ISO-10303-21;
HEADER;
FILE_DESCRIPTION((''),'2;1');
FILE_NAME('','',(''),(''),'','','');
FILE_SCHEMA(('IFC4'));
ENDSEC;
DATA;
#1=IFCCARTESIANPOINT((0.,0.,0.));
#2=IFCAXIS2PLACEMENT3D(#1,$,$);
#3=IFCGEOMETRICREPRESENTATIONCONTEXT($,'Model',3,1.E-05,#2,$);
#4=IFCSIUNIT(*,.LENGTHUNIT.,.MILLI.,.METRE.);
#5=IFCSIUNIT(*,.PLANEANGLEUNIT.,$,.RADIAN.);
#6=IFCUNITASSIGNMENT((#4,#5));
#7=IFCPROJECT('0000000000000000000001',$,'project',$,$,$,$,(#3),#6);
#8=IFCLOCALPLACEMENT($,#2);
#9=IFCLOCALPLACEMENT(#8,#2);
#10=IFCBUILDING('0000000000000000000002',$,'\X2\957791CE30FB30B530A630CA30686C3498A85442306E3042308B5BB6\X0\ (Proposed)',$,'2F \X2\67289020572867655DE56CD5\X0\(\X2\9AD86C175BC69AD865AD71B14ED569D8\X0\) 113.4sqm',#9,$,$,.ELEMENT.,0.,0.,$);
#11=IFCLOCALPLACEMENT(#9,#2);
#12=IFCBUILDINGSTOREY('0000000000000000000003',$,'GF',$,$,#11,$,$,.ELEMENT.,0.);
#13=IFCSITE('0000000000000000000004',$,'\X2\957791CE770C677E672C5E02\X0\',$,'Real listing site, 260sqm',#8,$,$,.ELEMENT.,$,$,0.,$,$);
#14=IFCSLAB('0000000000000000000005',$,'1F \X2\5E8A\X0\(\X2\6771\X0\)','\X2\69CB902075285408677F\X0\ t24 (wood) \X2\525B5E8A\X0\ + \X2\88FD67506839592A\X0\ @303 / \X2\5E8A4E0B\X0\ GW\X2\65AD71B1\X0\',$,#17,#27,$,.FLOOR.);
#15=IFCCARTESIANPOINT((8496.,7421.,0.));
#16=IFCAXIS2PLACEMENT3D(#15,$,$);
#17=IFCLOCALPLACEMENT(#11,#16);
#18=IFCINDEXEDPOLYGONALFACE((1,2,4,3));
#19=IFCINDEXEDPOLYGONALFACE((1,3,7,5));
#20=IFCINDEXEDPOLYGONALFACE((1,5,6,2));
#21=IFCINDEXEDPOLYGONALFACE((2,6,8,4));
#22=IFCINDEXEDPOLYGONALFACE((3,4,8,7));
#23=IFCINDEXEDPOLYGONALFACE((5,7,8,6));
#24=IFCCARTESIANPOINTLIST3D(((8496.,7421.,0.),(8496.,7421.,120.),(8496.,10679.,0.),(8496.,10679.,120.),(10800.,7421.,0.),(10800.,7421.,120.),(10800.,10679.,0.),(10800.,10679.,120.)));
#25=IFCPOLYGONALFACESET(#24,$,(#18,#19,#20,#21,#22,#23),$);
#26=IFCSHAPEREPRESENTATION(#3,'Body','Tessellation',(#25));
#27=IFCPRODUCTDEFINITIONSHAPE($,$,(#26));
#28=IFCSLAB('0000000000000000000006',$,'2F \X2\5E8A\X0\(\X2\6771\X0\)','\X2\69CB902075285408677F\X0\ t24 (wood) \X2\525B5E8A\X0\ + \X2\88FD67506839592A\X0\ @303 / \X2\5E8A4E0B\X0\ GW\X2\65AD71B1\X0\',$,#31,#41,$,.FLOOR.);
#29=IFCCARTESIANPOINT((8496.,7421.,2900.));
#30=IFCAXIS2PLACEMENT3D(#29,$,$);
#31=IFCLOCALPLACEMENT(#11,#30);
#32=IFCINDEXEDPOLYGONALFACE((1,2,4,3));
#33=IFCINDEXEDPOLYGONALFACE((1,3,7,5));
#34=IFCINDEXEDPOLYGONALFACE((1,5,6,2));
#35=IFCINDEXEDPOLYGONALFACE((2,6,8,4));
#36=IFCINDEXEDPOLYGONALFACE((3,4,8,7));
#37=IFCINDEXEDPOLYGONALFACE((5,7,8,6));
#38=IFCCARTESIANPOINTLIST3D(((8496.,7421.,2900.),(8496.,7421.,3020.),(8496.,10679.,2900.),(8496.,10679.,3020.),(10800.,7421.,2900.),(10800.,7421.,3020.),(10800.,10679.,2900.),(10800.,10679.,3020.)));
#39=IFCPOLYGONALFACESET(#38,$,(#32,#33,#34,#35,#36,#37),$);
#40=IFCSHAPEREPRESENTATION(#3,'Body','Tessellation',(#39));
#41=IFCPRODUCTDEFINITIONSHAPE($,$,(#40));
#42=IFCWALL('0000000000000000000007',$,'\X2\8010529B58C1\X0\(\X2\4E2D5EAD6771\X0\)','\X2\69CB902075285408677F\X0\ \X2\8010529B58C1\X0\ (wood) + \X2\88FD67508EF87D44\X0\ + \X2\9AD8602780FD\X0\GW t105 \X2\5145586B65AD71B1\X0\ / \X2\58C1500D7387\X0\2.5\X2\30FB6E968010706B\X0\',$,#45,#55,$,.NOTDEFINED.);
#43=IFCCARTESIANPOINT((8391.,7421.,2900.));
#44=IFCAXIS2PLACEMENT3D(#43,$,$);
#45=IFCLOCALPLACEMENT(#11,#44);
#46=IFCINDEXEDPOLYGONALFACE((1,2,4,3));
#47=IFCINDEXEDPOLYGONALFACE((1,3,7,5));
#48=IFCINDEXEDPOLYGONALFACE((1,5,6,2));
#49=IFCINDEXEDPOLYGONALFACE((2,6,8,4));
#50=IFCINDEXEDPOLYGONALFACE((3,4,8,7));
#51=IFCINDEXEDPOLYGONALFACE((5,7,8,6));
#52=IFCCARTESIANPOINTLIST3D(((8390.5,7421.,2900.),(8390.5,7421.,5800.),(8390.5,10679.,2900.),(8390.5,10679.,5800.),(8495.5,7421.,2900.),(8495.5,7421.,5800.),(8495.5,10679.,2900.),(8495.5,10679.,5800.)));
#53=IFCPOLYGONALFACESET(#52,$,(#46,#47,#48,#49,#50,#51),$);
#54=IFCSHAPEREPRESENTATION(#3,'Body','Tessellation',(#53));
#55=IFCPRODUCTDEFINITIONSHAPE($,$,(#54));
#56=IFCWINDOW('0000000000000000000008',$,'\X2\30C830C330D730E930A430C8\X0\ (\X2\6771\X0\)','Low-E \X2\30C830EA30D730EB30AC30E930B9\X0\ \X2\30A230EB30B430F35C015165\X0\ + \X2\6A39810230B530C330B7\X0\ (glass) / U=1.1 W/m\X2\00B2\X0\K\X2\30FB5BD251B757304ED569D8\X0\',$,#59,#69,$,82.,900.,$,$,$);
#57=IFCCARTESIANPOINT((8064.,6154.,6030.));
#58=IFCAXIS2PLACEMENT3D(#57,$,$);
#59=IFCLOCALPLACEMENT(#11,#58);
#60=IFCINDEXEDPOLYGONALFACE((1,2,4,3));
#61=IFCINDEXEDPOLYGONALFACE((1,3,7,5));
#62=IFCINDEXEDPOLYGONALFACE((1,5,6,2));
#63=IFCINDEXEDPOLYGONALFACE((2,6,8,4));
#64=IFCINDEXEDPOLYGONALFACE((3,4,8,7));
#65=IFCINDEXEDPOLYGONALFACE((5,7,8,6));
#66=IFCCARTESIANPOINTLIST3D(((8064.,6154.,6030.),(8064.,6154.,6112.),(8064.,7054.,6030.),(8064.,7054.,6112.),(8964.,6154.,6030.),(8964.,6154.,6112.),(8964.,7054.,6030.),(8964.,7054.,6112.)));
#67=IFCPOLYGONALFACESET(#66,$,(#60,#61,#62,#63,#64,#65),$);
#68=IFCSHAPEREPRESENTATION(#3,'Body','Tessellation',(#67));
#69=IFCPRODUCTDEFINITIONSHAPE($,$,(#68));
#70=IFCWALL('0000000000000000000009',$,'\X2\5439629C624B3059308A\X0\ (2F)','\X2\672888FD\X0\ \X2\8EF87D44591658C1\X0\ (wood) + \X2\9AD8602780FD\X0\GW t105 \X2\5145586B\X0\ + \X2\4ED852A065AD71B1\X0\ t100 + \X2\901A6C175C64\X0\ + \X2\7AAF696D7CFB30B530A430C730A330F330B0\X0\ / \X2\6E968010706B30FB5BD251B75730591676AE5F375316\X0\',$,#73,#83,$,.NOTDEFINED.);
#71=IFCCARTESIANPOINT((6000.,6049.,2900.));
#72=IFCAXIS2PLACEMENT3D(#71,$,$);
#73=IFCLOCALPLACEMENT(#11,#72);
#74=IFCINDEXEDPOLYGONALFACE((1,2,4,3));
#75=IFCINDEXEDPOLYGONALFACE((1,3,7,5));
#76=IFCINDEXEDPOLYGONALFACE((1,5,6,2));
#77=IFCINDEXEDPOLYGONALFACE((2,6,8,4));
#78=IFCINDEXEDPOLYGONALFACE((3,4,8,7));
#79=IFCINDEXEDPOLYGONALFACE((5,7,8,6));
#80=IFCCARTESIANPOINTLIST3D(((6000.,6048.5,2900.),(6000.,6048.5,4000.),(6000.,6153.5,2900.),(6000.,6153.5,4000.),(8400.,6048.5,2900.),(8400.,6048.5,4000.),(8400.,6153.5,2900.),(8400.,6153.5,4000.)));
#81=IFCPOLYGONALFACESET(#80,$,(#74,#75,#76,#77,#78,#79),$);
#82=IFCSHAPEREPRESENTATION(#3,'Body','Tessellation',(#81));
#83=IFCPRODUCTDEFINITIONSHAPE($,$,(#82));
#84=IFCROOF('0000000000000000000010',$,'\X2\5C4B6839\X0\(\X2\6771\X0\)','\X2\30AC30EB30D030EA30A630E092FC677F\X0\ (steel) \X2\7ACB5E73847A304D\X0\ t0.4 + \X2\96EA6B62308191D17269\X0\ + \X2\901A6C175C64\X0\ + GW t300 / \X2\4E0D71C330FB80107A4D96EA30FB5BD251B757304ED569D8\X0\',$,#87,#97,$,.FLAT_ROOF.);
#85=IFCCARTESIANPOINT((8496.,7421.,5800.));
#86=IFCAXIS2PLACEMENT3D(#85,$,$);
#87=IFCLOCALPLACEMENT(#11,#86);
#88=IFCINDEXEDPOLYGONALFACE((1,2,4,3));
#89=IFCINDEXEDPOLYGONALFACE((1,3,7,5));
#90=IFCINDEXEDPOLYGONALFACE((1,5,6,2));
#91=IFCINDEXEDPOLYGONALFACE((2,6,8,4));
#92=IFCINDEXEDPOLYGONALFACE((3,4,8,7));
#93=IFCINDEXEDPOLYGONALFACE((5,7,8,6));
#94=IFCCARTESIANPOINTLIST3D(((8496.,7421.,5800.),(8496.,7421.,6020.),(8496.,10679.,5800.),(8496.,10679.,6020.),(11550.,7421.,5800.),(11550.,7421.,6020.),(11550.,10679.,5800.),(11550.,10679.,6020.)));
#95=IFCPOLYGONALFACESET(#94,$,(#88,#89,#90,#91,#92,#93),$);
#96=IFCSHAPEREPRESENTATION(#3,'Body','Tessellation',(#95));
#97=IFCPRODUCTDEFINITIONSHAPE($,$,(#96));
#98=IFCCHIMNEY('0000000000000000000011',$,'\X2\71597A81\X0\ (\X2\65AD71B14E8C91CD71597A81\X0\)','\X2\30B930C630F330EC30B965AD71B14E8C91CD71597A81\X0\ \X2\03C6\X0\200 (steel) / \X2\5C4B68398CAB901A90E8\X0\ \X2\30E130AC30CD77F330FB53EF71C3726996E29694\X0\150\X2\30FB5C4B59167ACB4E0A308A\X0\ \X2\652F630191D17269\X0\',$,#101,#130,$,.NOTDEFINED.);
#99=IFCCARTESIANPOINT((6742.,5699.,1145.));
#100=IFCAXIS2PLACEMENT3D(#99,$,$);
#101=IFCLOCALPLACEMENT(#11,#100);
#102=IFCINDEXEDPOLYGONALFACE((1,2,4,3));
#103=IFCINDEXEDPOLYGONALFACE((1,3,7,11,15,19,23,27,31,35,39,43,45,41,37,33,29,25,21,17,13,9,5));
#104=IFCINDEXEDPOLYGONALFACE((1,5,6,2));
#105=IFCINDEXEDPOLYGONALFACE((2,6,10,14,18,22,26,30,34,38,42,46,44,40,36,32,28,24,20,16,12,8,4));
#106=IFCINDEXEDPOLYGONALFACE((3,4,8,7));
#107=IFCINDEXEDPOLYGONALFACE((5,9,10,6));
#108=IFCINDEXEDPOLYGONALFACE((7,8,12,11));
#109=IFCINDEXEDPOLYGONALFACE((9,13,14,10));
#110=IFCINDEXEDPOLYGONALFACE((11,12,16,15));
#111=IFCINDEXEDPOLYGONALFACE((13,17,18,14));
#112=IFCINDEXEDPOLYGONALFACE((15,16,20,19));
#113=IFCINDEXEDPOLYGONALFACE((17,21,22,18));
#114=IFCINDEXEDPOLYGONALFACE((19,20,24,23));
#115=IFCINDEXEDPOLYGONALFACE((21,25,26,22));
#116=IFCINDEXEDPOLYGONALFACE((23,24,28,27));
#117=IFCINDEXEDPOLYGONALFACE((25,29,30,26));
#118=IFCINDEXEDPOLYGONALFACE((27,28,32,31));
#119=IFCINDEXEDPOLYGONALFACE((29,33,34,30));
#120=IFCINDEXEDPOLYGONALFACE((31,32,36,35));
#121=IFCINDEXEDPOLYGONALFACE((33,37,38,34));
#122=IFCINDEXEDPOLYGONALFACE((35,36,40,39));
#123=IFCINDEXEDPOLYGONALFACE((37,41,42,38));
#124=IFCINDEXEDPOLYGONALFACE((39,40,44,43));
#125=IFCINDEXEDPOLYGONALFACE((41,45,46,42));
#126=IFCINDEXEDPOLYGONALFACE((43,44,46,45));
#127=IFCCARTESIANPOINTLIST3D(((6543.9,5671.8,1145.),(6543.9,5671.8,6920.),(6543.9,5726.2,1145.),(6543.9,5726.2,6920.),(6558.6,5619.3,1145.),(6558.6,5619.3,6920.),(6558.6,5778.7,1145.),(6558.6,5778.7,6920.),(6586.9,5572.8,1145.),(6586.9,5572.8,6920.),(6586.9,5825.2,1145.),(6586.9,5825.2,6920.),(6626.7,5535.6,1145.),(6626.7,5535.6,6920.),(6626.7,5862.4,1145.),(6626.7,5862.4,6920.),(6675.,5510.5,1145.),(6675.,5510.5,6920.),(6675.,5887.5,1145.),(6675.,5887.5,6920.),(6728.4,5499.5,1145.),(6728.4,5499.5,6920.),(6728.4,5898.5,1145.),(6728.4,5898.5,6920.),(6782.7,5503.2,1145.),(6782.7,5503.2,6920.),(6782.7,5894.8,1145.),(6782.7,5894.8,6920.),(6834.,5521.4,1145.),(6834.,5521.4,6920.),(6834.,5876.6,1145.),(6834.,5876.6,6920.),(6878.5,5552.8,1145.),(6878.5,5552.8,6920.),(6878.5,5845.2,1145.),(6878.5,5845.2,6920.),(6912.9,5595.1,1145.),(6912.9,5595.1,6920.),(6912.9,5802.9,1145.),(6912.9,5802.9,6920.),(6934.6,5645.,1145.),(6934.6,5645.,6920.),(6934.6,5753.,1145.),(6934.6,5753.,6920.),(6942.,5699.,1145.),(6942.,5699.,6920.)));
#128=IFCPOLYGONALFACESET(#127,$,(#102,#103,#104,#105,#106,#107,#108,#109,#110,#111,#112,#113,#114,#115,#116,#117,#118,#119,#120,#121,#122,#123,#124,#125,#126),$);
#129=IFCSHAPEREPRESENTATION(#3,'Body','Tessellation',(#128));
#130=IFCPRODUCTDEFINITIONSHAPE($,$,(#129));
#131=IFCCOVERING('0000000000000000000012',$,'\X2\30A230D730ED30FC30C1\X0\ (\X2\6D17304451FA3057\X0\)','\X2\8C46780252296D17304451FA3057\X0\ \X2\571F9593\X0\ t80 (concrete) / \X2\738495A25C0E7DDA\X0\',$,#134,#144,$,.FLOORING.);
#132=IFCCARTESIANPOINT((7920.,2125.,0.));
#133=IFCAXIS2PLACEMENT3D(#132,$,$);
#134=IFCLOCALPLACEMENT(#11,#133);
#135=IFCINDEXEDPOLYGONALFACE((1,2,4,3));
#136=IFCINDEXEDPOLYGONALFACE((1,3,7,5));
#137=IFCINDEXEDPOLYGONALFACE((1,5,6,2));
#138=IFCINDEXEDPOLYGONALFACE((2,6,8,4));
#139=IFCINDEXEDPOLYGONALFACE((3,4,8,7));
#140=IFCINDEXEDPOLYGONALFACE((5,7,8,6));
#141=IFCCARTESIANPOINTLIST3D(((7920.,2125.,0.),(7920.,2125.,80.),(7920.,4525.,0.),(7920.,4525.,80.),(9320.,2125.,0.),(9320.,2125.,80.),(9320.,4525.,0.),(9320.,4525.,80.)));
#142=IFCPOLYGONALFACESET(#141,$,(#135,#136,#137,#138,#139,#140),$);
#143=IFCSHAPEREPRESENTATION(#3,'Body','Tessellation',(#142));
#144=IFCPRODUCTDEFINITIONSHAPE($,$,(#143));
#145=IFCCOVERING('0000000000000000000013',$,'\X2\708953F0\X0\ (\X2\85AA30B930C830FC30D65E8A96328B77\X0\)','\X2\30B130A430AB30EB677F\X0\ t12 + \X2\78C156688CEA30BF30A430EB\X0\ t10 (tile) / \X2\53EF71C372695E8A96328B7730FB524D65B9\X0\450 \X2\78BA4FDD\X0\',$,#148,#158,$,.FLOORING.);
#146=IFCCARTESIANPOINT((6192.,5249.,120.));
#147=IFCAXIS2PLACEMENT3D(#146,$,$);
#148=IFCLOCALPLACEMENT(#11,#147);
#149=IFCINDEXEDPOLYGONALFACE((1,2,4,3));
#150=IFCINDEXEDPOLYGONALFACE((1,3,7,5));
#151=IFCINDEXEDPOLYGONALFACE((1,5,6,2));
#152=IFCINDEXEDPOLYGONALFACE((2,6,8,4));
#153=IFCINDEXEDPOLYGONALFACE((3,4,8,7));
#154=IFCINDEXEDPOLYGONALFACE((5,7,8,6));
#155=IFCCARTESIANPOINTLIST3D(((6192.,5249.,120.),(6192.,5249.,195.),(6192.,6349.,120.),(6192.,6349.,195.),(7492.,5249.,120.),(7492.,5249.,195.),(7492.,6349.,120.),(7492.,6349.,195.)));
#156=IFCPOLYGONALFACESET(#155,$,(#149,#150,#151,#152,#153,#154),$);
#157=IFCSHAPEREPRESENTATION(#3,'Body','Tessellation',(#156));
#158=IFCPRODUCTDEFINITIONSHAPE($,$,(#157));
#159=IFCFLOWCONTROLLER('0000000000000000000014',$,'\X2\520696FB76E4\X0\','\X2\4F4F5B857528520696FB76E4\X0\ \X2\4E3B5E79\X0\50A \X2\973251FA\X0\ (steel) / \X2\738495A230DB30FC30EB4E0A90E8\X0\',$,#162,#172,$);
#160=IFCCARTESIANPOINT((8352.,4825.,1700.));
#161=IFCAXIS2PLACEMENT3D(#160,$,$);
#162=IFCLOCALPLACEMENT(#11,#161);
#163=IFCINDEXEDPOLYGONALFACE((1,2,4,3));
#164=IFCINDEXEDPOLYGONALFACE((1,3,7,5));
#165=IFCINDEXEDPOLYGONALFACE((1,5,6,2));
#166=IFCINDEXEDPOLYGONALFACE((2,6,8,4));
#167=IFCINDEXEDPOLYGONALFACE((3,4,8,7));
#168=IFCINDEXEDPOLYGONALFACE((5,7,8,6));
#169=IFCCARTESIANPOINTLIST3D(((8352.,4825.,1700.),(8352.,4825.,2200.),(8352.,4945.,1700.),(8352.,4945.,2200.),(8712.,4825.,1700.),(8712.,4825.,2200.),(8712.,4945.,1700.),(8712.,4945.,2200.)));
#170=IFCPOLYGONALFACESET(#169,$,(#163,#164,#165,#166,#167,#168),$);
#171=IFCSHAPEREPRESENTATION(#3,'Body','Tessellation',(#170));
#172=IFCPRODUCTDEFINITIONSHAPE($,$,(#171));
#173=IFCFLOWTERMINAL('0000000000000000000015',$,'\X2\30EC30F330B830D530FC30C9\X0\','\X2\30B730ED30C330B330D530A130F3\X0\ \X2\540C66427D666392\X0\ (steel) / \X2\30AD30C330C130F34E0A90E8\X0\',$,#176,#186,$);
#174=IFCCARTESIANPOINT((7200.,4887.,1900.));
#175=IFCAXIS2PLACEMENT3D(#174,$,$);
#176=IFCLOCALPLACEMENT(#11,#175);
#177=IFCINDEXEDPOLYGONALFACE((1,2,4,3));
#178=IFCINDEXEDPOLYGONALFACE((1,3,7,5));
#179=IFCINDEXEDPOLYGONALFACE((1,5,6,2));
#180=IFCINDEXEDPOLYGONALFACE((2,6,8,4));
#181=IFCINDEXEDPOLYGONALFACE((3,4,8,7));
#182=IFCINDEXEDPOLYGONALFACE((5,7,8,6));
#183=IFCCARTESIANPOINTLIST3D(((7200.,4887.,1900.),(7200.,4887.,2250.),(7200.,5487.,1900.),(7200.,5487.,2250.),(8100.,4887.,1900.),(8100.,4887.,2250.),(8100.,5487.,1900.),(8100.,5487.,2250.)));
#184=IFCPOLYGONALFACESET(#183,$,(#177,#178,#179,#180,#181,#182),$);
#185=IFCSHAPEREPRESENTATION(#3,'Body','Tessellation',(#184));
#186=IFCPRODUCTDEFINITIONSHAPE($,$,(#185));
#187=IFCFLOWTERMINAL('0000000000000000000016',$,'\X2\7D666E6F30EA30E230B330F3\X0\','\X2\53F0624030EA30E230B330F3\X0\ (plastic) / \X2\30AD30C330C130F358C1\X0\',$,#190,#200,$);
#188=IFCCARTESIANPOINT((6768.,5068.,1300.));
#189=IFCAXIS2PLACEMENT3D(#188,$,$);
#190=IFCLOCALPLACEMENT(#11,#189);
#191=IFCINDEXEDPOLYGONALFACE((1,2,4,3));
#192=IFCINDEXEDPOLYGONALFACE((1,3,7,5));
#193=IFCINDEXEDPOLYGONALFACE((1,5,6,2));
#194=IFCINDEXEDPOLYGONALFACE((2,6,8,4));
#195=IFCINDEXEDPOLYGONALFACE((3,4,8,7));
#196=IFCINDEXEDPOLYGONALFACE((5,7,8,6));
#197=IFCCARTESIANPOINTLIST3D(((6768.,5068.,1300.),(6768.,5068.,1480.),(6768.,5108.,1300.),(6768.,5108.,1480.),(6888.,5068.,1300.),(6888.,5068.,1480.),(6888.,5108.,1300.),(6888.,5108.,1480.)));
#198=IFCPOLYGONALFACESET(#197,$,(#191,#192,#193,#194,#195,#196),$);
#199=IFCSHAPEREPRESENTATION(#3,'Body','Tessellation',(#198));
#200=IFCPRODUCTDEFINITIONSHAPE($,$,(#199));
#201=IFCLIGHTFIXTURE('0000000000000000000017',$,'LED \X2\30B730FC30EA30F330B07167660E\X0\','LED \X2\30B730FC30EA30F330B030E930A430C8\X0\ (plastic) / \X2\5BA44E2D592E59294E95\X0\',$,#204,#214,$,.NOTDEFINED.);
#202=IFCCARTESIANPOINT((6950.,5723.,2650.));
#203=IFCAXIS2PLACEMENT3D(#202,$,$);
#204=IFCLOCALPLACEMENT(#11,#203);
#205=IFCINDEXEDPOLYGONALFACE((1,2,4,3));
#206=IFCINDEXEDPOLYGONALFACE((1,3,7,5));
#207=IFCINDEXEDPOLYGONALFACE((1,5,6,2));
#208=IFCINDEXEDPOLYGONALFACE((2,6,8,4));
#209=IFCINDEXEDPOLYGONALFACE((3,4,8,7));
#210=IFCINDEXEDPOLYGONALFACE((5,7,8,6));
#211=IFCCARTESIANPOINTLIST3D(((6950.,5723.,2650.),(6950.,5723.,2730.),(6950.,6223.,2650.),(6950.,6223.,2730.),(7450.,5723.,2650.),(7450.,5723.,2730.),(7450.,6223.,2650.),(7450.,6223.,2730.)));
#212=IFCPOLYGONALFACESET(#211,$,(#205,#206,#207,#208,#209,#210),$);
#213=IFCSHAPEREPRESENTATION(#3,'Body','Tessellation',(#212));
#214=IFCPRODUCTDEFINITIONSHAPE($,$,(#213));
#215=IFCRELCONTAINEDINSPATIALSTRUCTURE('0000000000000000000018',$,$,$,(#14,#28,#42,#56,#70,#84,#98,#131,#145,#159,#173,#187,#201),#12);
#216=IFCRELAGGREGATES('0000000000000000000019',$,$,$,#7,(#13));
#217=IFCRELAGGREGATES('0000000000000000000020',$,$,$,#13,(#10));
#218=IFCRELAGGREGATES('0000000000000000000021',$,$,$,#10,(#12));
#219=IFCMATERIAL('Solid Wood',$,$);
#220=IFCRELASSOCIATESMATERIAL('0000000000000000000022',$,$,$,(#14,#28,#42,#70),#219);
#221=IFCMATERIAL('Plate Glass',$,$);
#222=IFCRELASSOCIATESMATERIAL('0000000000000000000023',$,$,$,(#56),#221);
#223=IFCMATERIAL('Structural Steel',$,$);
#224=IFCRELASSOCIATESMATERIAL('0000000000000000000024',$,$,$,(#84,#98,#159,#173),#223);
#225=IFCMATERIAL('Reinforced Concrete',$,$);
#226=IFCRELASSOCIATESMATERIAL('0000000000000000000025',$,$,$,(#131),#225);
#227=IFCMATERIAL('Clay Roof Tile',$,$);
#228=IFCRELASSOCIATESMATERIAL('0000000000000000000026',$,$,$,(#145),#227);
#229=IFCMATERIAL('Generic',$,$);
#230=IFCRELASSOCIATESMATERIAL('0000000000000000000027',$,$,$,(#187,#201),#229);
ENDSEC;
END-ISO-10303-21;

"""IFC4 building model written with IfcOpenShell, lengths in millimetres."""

from ifc_helpers import new_model, si_unit, frame, frame_2d, origin, origin_2d, place, context, project, spatial, rectangle, circle, extrude, material, element, save


model = new_model("IFC4")

# Units and contexts
model_context = context("Model", 3, precision=1e-05, world=origin())
ifc_project = project(units=[si_unit("LENGTHUNIT", "METRE", prefix="MILLI"), si_unit("PLANEANGLEUNIT", "RADIAN")], contexts=[model_context])

# Site, building, storey
site_placement = place(None, origin())
site = spatial("IfcSite", under=ifc_project, at=site_placement, Name="長野県松本市", ObjectType="Real listing site, 260sqm", CompositionType="ELEMENT", RefElevation=0.0)
building_placement = place(site_placement, origin())
building = spatial("IfcBuilding", under=site, at=building_placement, Name="長野・サウナと水風呂のある家 (Proposed)", ObjectType="2F 木造在来工法(高気密高断熱仕様) 113.4sqm", CompositionType="ELEMENT", ElevationOfRefHeight=0.0, ElevationOfTerrain=0.0)
storey_placement = place(building_placement, origin())
storey = spatial("IfcBuildingStorey", under=building, at=storey_placement, Name="GF", CompositionType="ELEMENT", Elevation=0.0)

# Shared definitions
ifc_material_1 = material(Name="Solid Wood")

# Slabs
slab_1_placement = place(storey_placement, frame((8496.0, 7421.0, 0.0)))
element("IfcSlab", 1, at=slab_1_placement, inside=storey, material=ifc_material_1, Name="1F 床(東)", Description="構造用合板 t24 (wood) 剛床 + 製材根太 @303 / 床下 GW断熱", PredefinedType="FLOOR", context=model_context, shape_type="SweptSolid", body=[
    extrude(rectangle(XDim=2304.0, YDim=3258.0, at=frame_2d((1152.0, 1629.0))), frame((8496.0, 7421.0, 0.0)), (0.0, 0.0, 1.0), 120.0),
])
slab_2_placement = place(storey_placement, frame((8496.0, 7421.0, 2900.0)))
element("IfcSlab", 2, at=slab_2_placement, inside=storey, material=ifc_material_1, Name="2F 床(東)", Description="構造用合板 t24 (wood) 剛床 + 製材根太 @303 / 床下 GW断熱", PredefinedType="FLOOR", context=model_context, shape_type="SweptSolid", body=[
    extrude(rectangle(XDim=2304.0, YDim=3258.0, at=frame_2d((1152.0, 1629.0))), frame((8496.0, 7421.0, 2900.0)), (0.0, 0.0, 1.0), 120.0),
])

# Wall
wall_1_placement = place(storey_placement, frame((8391.0, 7421.0, 2900.0)))
element("IfcWall", 3, at=wall_1_placement, inside=storey, material=ifc_material_1, Name="耐力壁(中庭東)", Description="構造用合板 耐力壁 (wood) + 製材軸組 + 高性能GW t105 充填断熱 / 壁倍率2.5・準耐火", PredefinedType="NOTDEFINED", context=model_context, shape_type="SweptSolid", body=[
    extrude(rectangle(XDim=105.0, YDim=3258.0, at=frame_2d((52.0, 1629.0))), frame((8391.0, 7421.0, 2900.0)), (0.0, 0.0, 1.0), 2900.0),
])

# Window
ifc_material_2 = material(Name="Plate Glass")
window_placement = place(storey_placement, frame((8064.0, 6154.0, 6030.0)))
element("IfcWindow", 4, at=window_placement, inside=storey, material=ifc_material_2, Name="トップライト (東)", Description="Low-E トリプルガラス アルゴン封入 + 樹脂サッシ (glass) / U=1.1 W/m²K・寒冷地仕様", OverallHeight=82.0, OverallWidth=900.0, context=model_context, shape_type="SweptSolid", body=[
    extrude(rectangle(XDim=900.0, YDim=900.0, at=frame_2d((450.0, 450.0))), frame((8064.0, 6154.0, 6030.0)), (0.0, 0.0, 1.0), 82.0),
])

# Wall
wall_2_placement = place(storey_placement, frame((6000.0, 6049.0, 2900.0)))
element("IfcWall", 5, at=wall_2_placement, inside=storey, material=ifc_material_1, Name="吹抜手すり (2F)", Description="木製 軸組外壁 (wood) + 高性能GW t105 充填 + 付加断熱 t100 + 通気層 + 窯業系サイディング / 準耐火・寒冷地外皮強化", PredefinedType="NOTDEFINED", context=model_context, shape_type="SweptSolid", body=[
    extrude(rectangle(XDim=2400.0, YDim=105.0, at=frame_2d((1200.0, 52.0))), frame((6000.0, 6049.0, 2900.0)), (0.0, 0.0, 1.0), 1100.0),
])

# Roof
ifc_material_3 = material(Name="Structural Steel")
roof_placement = place(storey_placement, frame((8496.0, 7421.0, 5800.0)))
element("IfcRoof", 6, at=roof_placement, inside=storey, material=ifc_material_3, Name="屋根(東)", Description="ガルバリウム鋼板 (steel) 立平葺き t0.4 + 雪止め金物 + 通気層 + GW t300 / 不燃・耐積雪・寒冷地仕様", PredefinedType="FLAT_ROOF", context=model_context, shape_type="SweptSolid", body=[
    extrude(rectangle(XDim=3054.0, YDim=3258.0, at=frame_2d((1527.0, 1629.0))), frame((8496.0, 7421.0, 5800.0)), (0.0, 0.0, 1.0), 220.0),
])

# Chimney
chimney_placement = place(storey_placement, frame((6742.0, 5699.0, 1145.0)))
element("IfcChimney", 7, at=chimney_placement, inside=storey, material=ifc_material_3, Name="煙突 (断熱二重煙突)", Description="ステンレス断熱二重煙突 φ200 (steel) / 屋根貫通部 メガネ石・可燃物離隔150・屋外立上り 支持金物", PredefinedType="NOTDEFINED", context=model_context, shape_type="SweptSolid", body=[
    extrude(circle(Radius=200.0, at=origin_2d()), frame((6742.0, 5699.0, 1145.0)), (0.0, 0.0, 1.0), 5775.0),
])

# Coverings
ifc_material_4 = material(Name="Reinforced Concrete")
covering_1_placement = place(storey_placement, frame((7920.0, 2125.0, 0.0)))
element("IfcCovering", 8, at=covering_1_placement, inside=storey, material=ifc_material_4, Name="アプローチ (洗い出し)", Description="豆砂利洗い出し 土間 t80 (concrete) / 玄関導線", PredefinedType="FLOORING", context=model_context, shape_type="SweptSolid", body=[
    extrude(rectangle(XDim=1400.0, YDim=2400.0, at=frame_2d((700.0, 1200.0))), frame((7920.0, 2125.0, 0.0)), (0.0, 0.0, 1.0), 80.0),
])
ifc_material_5 = material(Name="Clay Roof Tile")
covering_2_placement = place(storey_placement, frame((6192.0, 5249.0, 120.0)))
element("IfcCovering", 9, at=covering_2_placement, inside=storey, material=ifc_material_5, Name="炉台 (薪ストーブ床防護)", Description="ケイカル板 t12 + 磁器質タイル t10 (tile) / 可燃物床防護・前方450 確保", PredefinedType="FLOORING", context=model_context, shape_type="SweptSolid", body=[
    extrude(rectangle(XDim=1300.0, YDim=1100.0, at=frame_2d((650.0, 550.0))), frame((6192.0, 5249.0, 120.0)), (0.0, 0.0, 1.0), 75.0),
])

# Flow controller
flow_controller_placement = place(storey_placement, frame((8352.0, 4825.0, 1700.0)))
element("IfcFlowController", 10, at=flow_controller_placement, inside=storey, material=ifc_material_3, Name="分電盤", Description="住宅用分電盤 主幹50A 露出 (steel) / 玄関ホール上部", context=model_context, shape_type="SweptSolid", body=[
    extrude(rectangle(XDim=360.0, YDim=120.0, at=frame_2d((180.0, 60.0))), frame((8352.0, 4825.0, 1700.0)), (0.0, 0.0, 1.0), 500.0),
])

# Flow terminals
flow_terminal_1_placement = place(storey_placement, frame((7200.0, 4887.0, 1900.0)))
element("IfcFlowTerminal", 11, at=flow_terminal_1_placement, inside=storey, material=ifc_material_3, Name="レンジフード", Description="シロッコファン 同時給排 (steel) / キッチン上部", context=model_context, shape_type="SweptSolid", body=[
    extrude(rectangle(XDim=900.0, YDim=600.0, at=frame_2d((450.0, 300.0))), frame((7200.0, 4887.0, 1900.0)), (0.0, 0.0, 1.0), 350.0),
])
ifc_material_6 = material(Name="Generic")
flow_terminal_2_placement = place(storey_placement, frame((6768.0, 5068.0, 1300.0)))
element("IfcFlowTerminal", 12, at=flow_terminal_2_placement, inside=storey, material=ifc_material_6, Name="給湯リモコン", Description="台所リモコン (plastic) / キッチン壁", context=model_context, shape_type="SweptSolid", body=[
    extrude(rectangle(XDim=120.0, YDim=40.0, at=frame_2d((60.0, 20.0))), frame((6768.0, 5068.0, 1300.0)), (0.0, 0.0, 1.0), 180.0),
])

# Light fixture
light_fixture_1_placement = place(storey_placement, frame((6950.0, 5723.0, 2650.0)))
element("IfcLightFixture", 13, at=light_fixture_1_placement, inside=storey, material=ifc_material_6, Name="LED シーリング照明", Description="LED シーリングライト (plastic) / 室中央天井", PredefinedType="NOTDEFINED", context=model_context, shape_type="SweptSolid", body=[
    extrude(rectangle(XDim=500.0, YDim=500.0, at=frame_2d((250.0, 250.0))), frame((6950.0, 5723.0, 2650.0)), (0.0, 0.0, 1.0), 80.0),
])

save(model, "model.ifc")
